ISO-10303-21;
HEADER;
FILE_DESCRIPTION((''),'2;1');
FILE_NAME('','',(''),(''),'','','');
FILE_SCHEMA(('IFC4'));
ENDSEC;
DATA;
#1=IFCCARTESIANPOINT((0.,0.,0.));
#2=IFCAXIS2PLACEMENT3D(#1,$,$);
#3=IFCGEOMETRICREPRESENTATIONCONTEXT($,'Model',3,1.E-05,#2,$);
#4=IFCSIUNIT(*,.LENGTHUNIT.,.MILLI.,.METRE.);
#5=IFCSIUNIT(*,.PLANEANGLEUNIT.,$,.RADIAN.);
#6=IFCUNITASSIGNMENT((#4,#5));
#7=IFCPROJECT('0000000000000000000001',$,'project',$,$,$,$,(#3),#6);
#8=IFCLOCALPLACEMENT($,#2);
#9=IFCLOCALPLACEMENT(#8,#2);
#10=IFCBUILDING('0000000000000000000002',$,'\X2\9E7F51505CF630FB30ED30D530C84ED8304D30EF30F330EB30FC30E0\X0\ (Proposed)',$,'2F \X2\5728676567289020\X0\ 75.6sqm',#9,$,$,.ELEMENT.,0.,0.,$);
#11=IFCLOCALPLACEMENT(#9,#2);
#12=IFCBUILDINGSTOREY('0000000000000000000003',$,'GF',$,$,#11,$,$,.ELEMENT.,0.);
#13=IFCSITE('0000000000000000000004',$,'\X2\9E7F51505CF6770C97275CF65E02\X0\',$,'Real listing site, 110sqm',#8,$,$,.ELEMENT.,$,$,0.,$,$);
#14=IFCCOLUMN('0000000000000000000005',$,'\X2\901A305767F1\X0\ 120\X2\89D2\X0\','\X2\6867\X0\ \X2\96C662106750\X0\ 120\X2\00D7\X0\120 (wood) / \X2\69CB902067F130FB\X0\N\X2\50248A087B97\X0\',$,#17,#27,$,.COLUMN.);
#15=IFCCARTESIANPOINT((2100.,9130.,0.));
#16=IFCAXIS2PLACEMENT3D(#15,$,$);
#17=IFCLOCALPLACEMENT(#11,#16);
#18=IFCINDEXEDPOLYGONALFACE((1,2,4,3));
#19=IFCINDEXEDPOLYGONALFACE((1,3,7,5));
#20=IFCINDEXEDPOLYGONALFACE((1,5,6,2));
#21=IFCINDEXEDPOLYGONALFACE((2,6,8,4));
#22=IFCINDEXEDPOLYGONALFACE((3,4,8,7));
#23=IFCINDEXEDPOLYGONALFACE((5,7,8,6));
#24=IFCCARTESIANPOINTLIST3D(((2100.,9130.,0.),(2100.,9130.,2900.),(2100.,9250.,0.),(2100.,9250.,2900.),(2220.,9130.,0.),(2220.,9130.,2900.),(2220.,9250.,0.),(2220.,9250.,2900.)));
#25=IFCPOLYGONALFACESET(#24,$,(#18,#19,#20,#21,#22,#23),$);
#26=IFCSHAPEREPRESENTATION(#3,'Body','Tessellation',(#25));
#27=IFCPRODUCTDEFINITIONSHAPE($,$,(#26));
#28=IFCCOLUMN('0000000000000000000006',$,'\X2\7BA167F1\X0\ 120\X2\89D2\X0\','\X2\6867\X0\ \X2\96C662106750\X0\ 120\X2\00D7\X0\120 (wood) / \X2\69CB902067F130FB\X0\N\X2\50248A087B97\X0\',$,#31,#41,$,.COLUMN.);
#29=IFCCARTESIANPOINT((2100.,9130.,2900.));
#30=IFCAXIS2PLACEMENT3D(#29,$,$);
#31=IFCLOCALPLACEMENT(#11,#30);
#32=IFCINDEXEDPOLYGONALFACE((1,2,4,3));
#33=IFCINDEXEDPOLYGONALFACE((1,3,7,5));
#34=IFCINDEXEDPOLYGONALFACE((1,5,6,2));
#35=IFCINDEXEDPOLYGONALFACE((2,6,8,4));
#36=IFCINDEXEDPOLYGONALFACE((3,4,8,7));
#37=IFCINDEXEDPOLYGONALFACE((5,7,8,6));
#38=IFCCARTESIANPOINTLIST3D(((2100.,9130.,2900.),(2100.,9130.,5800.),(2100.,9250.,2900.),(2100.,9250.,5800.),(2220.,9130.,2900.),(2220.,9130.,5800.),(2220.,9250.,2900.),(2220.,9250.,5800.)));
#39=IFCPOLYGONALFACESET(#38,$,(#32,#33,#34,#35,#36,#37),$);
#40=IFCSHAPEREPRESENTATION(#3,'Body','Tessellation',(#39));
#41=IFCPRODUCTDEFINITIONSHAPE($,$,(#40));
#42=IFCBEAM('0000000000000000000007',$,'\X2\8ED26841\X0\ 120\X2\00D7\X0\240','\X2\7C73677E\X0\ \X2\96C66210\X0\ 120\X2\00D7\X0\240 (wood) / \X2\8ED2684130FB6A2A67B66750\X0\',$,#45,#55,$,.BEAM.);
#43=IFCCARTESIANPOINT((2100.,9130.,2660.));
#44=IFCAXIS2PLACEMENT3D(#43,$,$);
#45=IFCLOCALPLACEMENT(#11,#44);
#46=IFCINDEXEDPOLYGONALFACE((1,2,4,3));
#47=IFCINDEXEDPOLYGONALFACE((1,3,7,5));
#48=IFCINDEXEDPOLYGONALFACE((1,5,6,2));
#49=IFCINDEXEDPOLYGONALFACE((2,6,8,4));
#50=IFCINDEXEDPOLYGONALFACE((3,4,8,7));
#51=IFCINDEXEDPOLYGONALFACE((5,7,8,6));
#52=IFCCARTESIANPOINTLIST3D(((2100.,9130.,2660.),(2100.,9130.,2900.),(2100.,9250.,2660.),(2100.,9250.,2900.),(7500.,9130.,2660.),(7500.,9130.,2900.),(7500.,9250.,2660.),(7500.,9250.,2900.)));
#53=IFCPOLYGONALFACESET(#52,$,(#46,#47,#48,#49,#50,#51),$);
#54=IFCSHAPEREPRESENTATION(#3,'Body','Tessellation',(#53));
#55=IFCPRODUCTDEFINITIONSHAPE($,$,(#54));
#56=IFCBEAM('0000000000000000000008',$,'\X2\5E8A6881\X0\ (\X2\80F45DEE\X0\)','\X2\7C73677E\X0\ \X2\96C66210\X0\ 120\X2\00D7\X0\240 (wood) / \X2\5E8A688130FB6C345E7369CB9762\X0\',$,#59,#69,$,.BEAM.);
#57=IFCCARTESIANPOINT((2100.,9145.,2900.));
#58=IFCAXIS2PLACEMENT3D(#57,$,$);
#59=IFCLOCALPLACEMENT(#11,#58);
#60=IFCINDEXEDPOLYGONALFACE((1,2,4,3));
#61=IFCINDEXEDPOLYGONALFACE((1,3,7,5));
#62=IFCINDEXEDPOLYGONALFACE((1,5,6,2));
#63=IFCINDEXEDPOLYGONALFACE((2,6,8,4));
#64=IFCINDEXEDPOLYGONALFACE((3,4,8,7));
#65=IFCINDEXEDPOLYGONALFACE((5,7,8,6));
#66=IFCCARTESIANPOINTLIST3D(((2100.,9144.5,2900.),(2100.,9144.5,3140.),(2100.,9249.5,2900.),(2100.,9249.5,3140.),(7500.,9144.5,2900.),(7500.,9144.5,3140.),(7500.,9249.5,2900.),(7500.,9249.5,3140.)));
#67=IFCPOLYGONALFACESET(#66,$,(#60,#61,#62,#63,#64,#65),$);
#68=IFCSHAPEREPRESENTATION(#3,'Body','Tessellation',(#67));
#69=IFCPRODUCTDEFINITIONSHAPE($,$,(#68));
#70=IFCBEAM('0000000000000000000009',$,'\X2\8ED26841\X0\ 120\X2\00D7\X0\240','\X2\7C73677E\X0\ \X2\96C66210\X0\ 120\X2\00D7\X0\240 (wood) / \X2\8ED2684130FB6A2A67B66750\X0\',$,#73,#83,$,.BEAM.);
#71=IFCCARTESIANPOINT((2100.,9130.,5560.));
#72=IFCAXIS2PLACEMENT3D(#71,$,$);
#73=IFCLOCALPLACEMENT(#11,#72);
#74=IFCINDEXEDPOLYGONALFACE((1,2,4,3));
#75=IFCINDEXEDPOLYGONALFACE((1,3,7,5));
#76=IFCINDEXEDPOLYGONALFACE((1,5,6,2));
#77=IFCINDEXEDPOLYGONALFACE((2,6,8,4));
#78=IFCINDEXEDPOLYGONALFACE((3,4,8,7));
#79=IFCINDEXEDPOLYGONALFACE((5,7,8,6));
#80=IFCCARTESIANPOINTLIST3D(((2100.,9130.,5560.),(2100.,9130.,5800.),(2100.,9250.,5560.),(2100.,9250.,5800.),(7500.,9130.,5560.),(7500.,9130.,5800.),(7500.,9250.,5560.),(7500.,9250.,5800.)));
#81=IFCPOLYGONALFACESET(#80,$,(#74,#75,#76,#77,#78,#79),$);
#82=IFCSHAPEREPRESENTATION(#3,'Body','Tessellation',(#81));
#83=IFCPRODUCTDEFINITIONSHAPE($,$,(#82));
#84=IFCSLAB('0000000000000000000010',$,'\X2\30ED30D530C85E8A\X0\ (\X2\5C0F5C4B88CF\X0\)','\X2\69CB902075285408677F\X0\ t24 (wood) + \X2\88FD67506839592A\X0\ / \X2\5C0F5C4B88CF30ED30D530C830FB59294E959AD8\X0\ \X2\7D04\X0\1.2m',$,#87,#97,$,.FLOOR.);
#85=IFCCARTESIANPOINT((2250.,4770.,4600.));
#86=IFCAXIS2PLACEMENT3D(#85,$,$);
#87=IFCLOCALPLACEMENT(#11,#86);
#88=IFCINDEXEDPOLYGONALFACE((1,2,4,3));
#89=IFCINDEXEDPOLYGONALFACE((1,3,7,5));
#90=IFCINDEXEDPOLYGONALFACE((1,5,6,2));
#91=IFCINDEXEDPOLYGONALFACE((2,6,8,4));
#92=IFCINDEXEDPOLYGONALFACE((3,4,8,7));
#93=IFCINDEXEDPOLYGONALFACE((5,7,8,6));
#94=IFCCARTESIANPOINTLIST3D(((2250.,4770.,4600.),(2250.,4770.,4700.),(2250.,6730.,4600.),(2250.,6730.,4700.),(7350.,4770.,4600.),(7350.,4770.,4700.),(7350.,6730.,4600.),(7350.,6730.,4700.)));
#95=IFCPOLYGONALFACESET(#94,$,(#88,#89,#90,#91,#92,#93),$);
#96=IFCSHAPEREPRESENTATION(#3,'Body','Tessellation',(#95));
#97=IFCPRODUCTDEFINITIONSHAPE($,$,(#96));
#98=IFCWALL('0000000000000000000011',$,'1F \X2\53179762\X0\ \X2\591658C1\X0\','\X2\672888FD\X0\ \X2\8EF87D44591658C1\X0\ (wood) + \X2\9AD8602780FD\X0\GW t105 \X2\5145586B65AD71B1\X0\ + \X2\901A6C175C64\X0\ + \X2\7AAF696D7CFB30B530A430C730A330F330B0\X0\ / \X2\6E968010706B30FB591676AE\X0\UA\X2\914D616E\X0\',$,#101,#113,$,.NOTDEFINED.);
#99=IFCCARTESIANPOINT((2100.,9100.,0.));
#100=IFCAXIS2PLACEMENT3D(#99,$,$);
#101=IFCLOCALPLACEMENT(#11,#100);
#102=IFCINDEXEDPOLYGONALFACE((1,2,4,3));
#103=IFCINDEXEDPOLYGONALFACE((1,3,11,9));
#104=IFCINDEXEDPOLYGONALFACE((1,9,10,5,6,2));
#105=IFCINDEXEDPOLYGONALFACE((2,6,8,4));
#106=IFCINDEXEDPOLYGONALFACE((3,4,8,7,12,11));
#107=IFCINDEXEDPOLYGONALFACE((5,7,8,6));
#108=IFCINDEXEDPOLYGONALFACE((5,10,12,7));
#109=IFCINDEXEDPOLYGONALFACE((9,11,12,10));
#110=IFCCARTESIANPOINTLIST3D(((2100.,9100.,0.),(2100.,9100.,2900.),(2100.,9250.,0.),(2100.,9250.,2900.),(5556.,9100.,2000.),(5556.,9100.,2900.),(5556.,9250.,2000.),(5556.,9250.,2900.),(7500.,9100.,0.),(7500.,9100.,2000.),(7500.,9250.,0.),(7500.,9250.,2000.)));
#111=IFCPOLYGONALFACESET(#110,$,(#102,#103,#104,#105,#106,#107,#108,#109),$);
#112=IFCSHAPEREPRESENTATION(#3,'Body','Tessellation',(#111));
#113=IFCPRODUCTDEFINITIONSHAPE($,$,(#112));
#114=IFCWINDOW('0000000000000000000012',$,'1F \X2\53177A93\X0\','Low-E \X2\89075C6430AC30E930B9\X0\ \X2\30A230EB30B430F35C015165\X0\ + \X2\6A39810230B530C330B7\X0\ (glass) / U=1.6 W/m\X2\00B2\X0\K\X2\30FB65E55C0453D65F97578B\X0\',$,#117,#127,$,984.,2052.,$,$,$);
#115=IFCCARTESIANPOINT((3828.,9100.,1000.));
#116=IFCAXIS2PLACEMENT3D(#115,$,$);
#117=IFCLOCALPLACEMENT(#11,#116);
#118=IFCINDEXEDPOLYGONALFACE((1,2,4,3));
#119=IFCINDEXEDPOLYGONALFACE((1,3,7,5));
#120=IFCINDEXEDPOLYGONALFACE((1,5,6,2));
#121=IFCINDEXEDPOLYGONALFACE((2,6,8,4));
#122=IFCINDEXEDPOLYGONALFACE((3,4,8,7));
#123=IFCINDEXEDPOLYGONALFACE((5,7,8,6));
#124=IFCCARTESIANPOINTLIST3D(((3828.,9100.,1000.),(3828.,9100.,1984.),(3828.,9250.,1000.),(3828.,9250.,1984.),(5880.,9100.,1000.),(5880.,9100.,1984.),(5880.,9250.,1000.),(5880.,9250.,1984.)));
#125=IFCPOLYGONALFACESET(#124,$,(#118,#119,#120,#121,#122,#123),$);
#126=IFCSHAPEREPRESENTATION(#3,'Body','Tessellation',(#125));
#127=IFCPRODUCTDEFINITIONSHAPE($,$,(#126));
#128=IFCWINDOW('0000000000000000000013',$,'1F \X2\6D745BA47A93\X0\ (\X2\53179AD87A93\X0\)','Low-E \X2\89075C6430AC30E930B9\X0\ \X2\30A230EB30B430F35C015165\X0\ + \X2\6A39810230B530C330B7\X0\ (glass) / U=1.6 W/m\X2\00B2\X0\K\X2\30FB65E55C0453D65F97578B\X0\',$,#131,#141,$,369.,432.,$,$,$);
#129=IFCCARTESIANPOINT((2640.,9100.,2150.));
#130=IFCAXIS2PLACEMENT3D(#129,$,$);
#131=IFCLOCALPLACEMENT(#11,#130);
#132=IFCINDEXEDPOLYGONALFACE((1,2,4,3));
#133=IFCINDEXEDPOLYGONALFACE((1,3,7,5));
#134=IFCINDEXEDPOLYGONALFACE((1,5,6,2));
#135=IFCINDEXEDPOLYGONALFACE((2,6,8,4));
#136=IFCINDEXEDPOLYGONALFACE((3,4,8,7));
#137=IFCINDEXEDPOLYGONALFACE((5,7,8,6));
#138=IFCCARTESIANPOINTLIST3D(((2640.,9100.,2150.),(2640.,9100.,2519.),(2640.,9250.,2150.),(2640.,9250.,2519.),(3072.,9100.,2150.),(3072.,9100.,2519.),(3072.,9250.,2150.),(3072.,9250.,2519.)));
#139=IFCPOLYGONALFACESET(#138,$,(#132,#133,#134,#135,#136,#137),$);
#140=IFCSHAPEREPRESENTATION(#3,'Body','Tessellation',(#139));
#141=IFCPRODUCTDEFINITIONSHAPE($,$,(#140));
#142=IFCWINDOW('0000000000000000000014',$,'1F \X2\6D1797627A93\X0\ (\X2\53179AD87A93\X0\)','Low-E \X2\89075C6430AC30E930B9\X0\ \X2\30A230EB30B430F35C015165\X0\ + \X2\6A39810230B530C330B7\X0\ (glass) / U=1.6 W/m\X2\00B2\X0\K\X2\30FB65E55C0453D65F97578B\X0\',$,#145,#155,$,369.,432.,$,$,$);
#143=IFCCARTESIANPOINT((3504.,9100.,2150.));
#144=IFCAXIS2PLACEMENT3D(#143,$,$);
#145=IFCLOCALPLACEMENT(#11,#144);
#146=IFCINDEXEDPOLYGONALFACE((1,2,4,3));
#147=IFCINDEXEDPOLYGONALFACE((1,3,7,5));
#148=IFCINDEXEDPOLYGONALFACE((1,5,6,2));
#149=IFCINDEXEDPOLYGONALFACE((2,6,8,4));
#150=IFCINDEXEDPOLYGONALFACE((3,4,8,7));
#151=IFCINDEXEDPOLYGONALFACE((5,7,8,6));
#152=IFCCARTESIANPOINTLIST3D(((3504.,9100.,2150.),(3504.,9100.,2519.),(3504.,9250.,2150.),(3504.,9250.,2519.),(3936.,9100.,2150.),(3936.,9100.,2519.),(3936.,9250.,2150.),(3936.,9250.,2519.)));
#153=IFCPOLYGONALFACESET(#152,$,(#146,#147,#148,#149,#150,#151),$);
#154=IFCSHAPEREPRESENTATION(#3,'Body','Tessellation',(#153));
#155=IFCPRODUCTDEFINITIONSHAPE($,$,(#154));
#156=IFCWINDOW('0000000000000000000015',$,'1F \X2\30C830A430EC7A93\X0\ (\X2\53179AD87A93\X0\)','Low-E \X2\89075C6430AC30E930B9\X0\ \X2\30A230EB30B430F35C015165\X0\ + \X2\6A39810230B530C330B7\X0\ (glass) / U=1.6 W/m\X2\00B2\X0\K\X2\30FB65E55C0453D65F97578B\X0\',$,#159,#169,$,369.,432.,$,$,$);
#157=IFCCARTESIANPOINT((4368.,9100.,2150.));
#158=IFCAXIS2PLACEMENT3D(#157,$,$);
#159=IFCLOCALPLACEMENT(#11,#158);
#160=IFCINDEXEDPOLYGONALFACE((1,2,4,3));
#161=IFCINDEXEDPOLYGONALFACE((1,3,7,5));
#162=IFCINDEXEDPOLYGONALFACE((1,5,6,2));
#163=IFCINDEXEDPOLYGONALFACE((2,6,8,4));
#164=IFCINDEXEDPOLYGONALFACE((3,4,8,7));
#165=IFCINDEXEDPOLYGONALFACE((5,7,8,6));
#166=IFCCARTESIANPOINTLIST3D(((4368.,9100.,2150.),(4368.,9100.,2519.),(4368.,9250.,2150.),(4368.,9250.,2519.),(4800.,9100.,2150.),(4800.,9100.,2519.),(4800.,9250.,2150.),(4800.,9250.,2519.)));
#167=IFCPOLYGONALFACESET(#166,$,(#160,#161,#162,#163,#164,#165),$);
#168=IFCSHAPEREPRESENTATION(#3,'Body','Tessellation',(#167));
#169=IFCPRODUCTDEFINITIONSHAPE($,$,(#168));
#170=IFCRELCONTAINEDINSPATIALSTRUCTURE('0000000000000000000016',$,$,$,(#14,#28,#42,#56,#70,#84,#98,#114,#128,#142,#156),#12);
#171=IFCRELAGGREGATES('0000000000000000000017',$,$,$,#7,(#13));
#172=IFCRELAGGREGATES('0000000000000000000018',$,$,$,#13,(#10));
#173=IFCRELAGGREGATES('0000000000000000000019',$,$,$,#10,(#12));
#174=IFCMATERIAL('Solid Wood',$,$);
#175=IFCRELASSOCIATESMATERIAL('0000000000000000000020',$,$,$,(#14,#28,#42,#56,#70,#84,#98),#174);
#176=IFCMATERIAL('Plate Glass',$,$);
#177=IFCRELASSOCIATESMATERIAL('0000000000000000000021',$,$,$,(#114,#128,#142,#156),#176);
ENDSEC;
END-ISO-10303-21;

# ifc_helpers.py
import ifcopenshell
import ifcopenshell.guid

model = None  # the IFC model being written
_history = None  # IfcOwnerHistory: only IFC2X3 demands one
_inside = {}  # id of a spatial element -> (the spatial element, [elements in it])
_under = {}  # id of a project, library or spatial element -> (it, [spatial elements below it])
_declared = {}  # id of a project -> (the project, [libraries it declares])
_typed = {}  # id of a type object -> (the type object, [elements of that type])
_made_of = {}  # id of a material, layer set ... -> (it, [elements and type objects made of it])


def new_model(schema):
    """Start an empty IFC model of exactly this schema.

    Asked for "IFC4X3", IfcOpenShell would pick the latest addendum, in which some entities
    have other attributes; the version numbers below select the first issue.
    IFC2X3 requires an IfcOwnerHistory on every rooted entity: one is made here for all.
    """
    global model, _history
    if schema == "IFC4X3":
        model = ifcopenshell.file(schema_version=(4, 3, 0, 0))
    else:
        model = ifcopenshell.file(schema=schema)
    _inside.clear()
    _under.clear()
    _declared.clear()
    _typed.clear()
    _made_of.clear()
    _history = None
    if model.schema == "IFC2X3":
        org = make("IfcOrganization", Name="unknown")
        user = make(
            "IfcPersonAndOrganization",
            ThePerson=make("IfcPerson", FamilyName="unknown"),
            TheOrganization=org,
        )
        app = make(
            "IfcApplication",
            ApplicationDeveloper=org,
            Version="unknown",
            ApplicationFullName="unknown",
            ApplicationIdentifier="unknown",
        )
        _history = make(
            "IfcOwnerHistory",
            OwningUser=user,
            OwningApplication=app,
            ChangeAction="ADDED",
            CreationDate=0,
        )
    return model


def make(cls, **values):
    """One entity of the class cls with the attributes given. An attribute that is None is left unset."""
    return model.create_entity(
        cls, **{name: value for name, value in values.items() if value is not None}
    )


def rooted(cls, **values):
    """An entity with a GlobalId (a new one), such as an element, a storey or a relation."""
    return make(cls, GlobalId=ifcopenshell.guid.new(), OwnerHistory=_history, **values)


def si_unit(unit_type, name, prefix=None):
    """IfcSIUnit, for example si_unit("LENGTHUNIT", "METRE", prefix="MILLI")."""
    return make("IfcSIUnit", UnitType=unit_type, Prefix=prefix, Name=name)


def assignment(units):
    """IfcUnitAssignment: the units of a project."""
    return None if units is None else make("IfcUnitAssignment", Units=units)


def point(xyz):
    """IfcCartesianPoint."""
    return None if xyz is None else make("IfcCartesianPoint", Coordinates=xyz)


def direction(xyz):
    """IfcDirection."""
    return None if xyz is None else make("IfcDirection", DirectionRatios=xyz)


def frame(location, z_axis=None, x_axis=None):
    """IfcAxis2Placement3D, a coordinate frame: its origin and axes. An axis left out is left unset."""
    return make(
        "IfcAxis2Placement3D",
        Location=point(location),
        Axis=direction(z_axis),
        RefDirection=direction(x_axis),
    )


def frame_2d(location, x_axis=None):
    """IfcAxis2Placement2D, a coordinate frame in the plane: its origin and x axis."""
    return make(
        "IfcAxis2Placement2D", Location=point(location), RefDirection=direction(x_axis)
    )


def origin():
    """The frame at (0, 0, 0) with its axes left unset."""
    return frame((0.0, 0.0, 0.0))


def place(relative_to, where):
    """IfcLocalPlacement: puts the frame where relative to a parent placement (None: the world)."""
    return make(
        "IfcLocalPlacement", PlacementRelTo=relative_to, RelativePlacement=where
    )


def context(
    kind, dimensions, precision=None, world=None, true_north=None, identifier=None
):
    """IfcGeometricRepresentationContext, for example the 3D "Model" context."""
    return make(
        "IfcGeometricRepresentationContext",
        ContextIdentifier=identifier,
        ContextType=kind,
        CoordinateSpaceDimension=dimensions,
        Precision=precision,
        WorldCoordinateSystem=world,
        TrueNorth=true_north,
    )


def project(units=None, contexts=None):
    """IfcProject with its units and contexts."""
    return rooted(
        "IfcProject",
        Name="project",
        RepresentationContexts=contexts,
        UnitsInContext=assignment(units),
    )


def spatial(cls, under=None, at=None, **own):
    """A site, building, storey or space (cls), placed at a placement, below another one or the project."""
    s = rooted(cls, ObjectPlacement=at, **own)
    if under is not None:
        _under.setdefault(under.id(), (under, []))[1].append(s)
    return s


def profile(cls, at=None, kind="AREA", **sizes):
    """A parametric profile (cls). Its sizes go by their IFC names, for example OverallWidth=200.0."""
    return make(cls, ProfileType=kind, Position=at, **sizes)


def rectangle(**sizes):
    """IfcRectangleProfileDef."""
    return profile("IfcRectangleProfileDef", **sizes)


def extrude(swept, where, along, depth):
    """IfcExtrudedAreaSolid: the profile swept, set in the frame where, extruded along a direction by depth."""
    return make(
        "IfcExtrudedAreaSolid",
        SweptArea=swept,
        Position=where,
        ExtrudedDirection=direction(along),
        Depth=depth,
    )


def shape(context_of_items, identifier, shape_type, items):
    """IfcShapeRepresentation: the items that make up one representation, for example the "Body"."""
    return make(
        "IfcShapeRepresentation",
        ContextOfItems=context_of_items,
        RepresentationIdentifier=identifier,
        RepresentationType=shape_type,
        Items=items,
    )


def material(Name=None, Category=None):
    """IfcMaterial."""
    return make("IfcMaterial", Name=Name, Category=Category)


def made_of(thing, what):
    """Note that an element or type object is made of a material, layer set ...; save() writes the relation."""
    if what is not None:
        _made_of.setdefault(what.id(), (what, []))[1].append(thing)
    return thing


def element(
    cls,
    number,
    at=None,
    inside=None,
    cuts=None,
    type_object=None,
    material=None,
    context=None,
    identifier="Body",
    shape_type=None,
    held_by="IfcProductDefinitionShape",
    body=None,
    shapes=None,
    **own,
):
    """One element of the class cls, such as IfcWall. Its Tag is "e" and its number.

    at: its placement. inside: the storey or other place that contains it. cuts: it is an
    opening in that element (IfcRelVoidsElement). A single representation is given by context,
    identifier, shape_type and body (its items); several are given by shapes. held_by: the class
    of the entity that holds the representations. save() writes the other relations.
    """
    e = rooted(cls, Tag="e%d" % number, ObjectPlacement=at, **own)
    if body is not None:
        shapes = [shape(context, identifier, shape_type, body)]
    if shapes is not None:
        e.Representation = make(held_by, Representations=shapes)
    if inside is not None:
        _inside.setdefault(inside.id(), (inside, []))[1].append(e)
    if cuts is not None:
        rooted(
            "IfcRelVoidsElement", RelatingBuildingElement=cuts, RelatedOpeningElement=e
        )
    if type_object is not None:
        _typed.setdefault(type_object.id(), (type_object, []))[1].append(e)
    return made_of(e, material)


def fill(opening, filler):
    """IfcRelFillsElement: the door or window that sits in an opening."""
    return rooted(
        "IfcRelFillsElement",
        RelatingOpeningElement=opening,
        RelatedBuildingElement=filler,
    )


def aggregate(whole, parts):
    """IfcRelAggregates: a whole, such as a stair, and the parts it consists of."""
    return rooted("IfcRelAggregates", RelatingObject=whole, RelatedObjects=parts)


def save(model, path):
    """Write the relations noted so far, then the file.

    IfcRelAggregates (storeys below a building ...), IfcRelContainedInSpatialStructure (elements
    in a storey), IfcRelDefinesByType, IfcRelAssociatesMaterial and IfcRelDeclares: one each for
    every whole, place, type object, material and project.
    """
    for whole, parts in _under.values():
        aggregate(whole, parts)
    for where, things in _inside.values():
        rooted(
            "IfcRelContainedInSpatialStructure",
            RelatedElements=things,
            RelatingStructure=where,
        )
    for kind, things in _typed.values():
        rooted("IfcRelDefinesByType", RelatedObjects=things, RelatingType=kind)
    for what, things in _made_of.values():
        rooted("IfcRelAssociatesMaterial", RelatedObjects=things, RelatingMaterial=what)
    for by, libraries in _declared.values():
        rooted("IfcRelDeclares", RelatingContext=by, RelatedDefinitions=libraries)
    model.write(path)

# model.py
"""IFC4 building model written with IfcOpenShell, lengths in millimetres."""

from ifc_helpers import new_model, si_unit, frame, frame_2d, origin, place, context, project, spatial, rectangle, extrude, material, element, fill, save


model = new_model("IFC4")

# Units and contexts
model_context = context("Model", 3, precision=1e-05, world=origin())
ifc_project = project(units=[si_unit("LENGTHUNIT", "METRE", prefix="MILLI"), si_unit("PLANEANGLEUNIT", "RADIAN")], contexts=[model_context])

# Site, building, storey
site_placement = place(None, origin())
site = spatial("IfcSite", under=ifc_project, at=site_placement, Name="鹿児島県霧島市", ObjectType="Real listing site, 110sqm", CompositionType="ELEMENT", RefElevation=0.0)
building_placement = place(site_placement, origin())
building = spatial("IfcBuilding", under=site, at=building_placement, Name="鹿児島・ロフト付きワンルーム (Proposed)", ObjectType="2F 在来木造 75.6sqm", CompositionType="ELEMENT", ElevationOfRefHeight=0.0, ElevationOfTerrain=0.0)
storey_placement = place(building_placement, origin())
storey = spatial("IfcBuildingStorey", under=building, at=storey_placement, Name="GF", CompositionType="ELEMENT", Elevation=0.0)

# Columns
ifc_material_1 = material(Name="Solid Wood")
column_1_placement = place(storey_placement, frame((2100.0, 9130.0, 0.0)))
element("IfcColumn", 1, at=column_1_placement, inside=storey, material=ifc_material_1, Name="通し柱 120角", Description="桧 集成材 120×120 (wood) / 構造柱・N値計算", PredefinedType="COLUMN", context=model_context, shape_type="SweptSolid", body=[
    extrude(rectangle(XDim=120.0, YDim=120.0, at=frame_2d((60.0, 60.0))), frame((2100.0, 9130.0, 0.0)), (0.0, 0.0, 1.0), 2900.0),
])
column_2_placement = place(storey_placement, frame((2100.0, 9130.0, 2900.0)))
element("IfcColumn", 2, at=column_2_placement, inside=storey, material=ifc_material_1, Name="管柱 120角", Description="桧 集成材 120×120 (wood) / 構造柱・N値計算", PredefinedType="COLUMN", context=model_context, shape_type="SweptSolid", body=[
    extrude(rectangle(XDim=120.0, YDim=120.0, at=frame_2d((60.0, 60.0))), frame((2100.0, 9130.0, 2900.0)), (0.0, 0.0, 1.0), 2900.0),
])

# Beams
beam_1_placement = place(storey_placement, frame((2100.0, 9130.0, 2660.0)))
element("IfcBeam", 3, at=beam_1_placement, inside=storey, material=ifc_material_1, Name="軒桁 120×240", Description="米松 集成 120×240 (wood) / 軒桁・横架材", PredefinedType="BEAM", context=model_context, shape_type="SweptSolid", body=[
    extrude(rectangle(XDim=5400.0, YDim=120.0, at=frame_2d((2700.0, 60.0))), frame((2100.0, 9130.0, 2660.0)), (0.0, 0.0, 1.0), 240.0),
])
beam_2_placement = place(storey_placement, frame((2100.0, 9145.0, 2900.0)))
element("IfcBeam", 4, at=beam_2_placement, inside=storey, material=ifc_material_1, Name="床梁 (胴差)", Description="米松 集成 120×240 (wood) / 床梁・水平構面", PredefinedType="BEAM", context=model_context, shape_type="SweptSolid", body=[
    extrude(rectangle(XDim=5400.0, YDim=105.0, at=frame_2d((2700.0, 52.0))), frame((2100.0, 9145.0, 2900.0)), (0.0, 0.0, 1.0), 240.0),
])
beam_3_placement = place(storey_placement, frame((2100.0, 9130.0, 5560.0)))
element("IfcBeam", 5, at=beam_3_placement, inside=storey, material=ifc_material_1, Name="軒桁 120×240", Description="米松 集成 120×240 (wood) / 軒桁・横架材", PredefinedType="BEAM", context=model_context, shape_type="SweptSolid", body=[
    extrude(rectangle(XDim=5400.0, YDim=120.0, at=frame_2d((2700.0, 60.0))), frame((2100.0, 9130.0, 5560.0)), (0.0, 0.0, 1.0), 240.0),
])

# Slab
slab_placement = place(storey_placement, frame((2250.0, 4770.0, 4600.0)))
element("IfcSlab", 6, at=slab_placement, inside=storey, material=ifc_material_1, Name="ロフト床 (小屋裏)", Description="構造用合板 t24 (wood) + 製材根太 / 小屋裏ロフト・天井高 約1.2m", PredefinedType="FLOOR", context=model_context, shape_type="SweptSolid", body=[
    extrude(rectangle(XDim=5100.0, YDim=1960.0, at=frame_2d((2550.0, 980.0))), frame((2250.0, 4770.0, 4600.0)), (0.0, 0.0, 1.0), 100.0),
])

# Wall, openings, windows
wall_1_placement = place(storey_placement, frame((2100.0, 9100.0, 0.0)))
wall_1 = element("IfcWall", 7, at=wall_1_placement, inside=storey, material=ifc_material_1, Name="1F 北面 外壁", Description="木製 軸組外壁 (wood) + 高性能GW t105 充填断熱 + 通気層 + 窯業系サイディング / 準耐火・外皮UA配慮", PredefinedType="NOTDEFINED", context=model_context, shape_type="SweptSolid", body=[
    extrude(rectangle(XDim=5400.0, YDim=150.0, at=frame_2d((2700.0, 75.0))), frame((2100.0, 9100.0, 0.0)), (0.0, 0.0, 1.0), 2900.0),
])
opening_1_placement = place(storey_placement, frame((3828.0, 9100.0, 1000.0)))
opening_1 = element("IfcOpeningElement", 8, at=opening_1_placement, cuts=wall_1, PredefinedType="NOTDEFINED", context=model_context, shape_type="SweptSolid", body=[
    extrude(rectangle(XDim=2052.0, YDim=150.0, at=frame_2d((1026.0, 75.0))), frame((3828.0, 9100.0, 1000.0)), (0.0, 0.0, 1.0), 984.0),
])
opening_2_placement = place(storey_placement, frame((2640.0, 9100.0, 2150.0)))
opening_2 = element("IfcOpeningElement", 9, at=opening_2_placement, cuts=wall_1, PredefinedType="NOTDEFINED", context=model_context, shape_type="SweptSolid", body=[
    extrude(rectangle(XDim=432.0, YDim=150.0, at=frame_2d((216.0, 75.0))), frame((2640.0, 9100.0, 2150.0)), (0.0, 0.0, 1.0), 369.0),
])
opening_3_placement = place(storey_placement, frame((3504.0, 9100.0, 2150.0)))
opening_3 = element("IfcOpeningElement", 10, at=opening_3_placement, cuts=wall_1, PredefinedType="NOTDEFINED", context=model_context, shape_type="SweptSolid", body=[
    extrude(rectangle(XDim=432.0, YDim=150.0, at=frame_2d((216.0, 75.0))), frame((3504.0, 9100.0, 2150.0)), (0.0, 0.0, 1.0), 369.0),
])
opening_4_placement = place(storey_placement, frame((4368.0, 9100.0, 2150.0)))
opening_4 = element("IfcOpeningElement", 11, at=opening_4_placement, cuts=wall_1, PredefinedType="NOTDEFINED", context=model_context, shape_type="SweptSolid", body=[
    extrude(rectangle(XDim=432.0, YDim=150.0, at=frame_2d((216.0, 75.0))), frame((4368.0, 9100.0, 2150.0)), (0.0, 0.0, 1.0), 369.0),
])
ifc_material_2 = material(Name="Plate Glass")
window_1_placement = place(storey_placement, frame((3828.0, 9100.0, 1000.0)))
window_1 = element("IfcWindow", 12, at=window_1_placement, inside=storey, material=ifc_material_2, Name="1F 北窓", Description="Low-E 複層ガラス アルゴン封入 + 樹脂サッシ (glass) / U=1.6 W/m²K・日射取得型", OverallHeight=984.0, OverallWidth=2052.0, context=model_context, shape_type="SweptSolid", body=[
    extrude(rectangle(XDim=2052.0, YDim=150.0, at=frame_2d((1026.0, 75.0))), frame((3828.0, 9100.0, 1000.0)), (0.0, 0.0, 1.0), 984.0),
])
fill(opening_1, window_1)
window_2_placement = place(storey_placement, frame((2640.0, 9100.0, 2150.0)))
window_2 = element("IfcWindow", 13, at=window_2_placement, inside=storey, material=ifc_material_2, Name="1F 浴室窓 (北高窓)", Description="Low-E 複層ガラス アルゴン封入 + 樹脂サッシ (glass) / U=1.6 W/m²K・日射取得型", OverallHeight=369.0, OverallWidth=432.0, context=model_context, shape_type="SweptSolid", body=[
    extrude(rectangle(XDim=432.0, YDim=150.0, at=frame_2d((216.0, 75.0))), frame((2640.0, 9100.0, 2150.0)), (0.0, 0.0, 1.0), 369.0),
])
fill(opening_2, window_2)
window_3_placement = place(storey_placement, frame((3504.0, 9100.0, 2150.0)))
window_3 = element("IfcWindow", 14, at=window_3_placement, inside=storey, material=ifc_material_2, Name="1F 洗面窓 (北高窓)", Description="Low-E 複層ガラス アルゴン封入 + 樹脂サッシ (glass) / U=1.6 W/m²K・日射取得型", OverallHeight=369.0, OverallWidth=432.0, context=model_context, shape_type="SweptSolid", body=[
    extrude(rectangle(XDim=432.0, YDim=150.0, at=frame_2d((216.0, 75.0))), frame((3504.0, 9100.0, 2150.0)), (0.0, 0.0, 1.0), 369.0),
])
fill(opening_3, window_3)
window_4_placement = place(storey_placement, frame((4368.0, 9100.0, 2150.0)))
window_4 = element("IfcWindow", 15, at=window_4_placement, inside=storey, material=ifc_material_2, Name="1F トイレ窓 (北高窓)", Description="Low-E 複層ガラス アルゴン封入 + 樹脂サッシ (glass) / U=1.6 W/m²K・日射取得型", OverallHeight=369.0, OverallWidth=432.0, context=model_context, shape_type="SweptSolid", body=[
    extrude(rectangle(XDim=432.0, YDim=150.0, at=frame_2d((216.0, 75.0))), frame((4368.0, 9100.0, 2150.0)), (0.0, 0.0, 1.0), 369.0),
])
fill(opening_4, window_4)

save(model, "model.ifc")
